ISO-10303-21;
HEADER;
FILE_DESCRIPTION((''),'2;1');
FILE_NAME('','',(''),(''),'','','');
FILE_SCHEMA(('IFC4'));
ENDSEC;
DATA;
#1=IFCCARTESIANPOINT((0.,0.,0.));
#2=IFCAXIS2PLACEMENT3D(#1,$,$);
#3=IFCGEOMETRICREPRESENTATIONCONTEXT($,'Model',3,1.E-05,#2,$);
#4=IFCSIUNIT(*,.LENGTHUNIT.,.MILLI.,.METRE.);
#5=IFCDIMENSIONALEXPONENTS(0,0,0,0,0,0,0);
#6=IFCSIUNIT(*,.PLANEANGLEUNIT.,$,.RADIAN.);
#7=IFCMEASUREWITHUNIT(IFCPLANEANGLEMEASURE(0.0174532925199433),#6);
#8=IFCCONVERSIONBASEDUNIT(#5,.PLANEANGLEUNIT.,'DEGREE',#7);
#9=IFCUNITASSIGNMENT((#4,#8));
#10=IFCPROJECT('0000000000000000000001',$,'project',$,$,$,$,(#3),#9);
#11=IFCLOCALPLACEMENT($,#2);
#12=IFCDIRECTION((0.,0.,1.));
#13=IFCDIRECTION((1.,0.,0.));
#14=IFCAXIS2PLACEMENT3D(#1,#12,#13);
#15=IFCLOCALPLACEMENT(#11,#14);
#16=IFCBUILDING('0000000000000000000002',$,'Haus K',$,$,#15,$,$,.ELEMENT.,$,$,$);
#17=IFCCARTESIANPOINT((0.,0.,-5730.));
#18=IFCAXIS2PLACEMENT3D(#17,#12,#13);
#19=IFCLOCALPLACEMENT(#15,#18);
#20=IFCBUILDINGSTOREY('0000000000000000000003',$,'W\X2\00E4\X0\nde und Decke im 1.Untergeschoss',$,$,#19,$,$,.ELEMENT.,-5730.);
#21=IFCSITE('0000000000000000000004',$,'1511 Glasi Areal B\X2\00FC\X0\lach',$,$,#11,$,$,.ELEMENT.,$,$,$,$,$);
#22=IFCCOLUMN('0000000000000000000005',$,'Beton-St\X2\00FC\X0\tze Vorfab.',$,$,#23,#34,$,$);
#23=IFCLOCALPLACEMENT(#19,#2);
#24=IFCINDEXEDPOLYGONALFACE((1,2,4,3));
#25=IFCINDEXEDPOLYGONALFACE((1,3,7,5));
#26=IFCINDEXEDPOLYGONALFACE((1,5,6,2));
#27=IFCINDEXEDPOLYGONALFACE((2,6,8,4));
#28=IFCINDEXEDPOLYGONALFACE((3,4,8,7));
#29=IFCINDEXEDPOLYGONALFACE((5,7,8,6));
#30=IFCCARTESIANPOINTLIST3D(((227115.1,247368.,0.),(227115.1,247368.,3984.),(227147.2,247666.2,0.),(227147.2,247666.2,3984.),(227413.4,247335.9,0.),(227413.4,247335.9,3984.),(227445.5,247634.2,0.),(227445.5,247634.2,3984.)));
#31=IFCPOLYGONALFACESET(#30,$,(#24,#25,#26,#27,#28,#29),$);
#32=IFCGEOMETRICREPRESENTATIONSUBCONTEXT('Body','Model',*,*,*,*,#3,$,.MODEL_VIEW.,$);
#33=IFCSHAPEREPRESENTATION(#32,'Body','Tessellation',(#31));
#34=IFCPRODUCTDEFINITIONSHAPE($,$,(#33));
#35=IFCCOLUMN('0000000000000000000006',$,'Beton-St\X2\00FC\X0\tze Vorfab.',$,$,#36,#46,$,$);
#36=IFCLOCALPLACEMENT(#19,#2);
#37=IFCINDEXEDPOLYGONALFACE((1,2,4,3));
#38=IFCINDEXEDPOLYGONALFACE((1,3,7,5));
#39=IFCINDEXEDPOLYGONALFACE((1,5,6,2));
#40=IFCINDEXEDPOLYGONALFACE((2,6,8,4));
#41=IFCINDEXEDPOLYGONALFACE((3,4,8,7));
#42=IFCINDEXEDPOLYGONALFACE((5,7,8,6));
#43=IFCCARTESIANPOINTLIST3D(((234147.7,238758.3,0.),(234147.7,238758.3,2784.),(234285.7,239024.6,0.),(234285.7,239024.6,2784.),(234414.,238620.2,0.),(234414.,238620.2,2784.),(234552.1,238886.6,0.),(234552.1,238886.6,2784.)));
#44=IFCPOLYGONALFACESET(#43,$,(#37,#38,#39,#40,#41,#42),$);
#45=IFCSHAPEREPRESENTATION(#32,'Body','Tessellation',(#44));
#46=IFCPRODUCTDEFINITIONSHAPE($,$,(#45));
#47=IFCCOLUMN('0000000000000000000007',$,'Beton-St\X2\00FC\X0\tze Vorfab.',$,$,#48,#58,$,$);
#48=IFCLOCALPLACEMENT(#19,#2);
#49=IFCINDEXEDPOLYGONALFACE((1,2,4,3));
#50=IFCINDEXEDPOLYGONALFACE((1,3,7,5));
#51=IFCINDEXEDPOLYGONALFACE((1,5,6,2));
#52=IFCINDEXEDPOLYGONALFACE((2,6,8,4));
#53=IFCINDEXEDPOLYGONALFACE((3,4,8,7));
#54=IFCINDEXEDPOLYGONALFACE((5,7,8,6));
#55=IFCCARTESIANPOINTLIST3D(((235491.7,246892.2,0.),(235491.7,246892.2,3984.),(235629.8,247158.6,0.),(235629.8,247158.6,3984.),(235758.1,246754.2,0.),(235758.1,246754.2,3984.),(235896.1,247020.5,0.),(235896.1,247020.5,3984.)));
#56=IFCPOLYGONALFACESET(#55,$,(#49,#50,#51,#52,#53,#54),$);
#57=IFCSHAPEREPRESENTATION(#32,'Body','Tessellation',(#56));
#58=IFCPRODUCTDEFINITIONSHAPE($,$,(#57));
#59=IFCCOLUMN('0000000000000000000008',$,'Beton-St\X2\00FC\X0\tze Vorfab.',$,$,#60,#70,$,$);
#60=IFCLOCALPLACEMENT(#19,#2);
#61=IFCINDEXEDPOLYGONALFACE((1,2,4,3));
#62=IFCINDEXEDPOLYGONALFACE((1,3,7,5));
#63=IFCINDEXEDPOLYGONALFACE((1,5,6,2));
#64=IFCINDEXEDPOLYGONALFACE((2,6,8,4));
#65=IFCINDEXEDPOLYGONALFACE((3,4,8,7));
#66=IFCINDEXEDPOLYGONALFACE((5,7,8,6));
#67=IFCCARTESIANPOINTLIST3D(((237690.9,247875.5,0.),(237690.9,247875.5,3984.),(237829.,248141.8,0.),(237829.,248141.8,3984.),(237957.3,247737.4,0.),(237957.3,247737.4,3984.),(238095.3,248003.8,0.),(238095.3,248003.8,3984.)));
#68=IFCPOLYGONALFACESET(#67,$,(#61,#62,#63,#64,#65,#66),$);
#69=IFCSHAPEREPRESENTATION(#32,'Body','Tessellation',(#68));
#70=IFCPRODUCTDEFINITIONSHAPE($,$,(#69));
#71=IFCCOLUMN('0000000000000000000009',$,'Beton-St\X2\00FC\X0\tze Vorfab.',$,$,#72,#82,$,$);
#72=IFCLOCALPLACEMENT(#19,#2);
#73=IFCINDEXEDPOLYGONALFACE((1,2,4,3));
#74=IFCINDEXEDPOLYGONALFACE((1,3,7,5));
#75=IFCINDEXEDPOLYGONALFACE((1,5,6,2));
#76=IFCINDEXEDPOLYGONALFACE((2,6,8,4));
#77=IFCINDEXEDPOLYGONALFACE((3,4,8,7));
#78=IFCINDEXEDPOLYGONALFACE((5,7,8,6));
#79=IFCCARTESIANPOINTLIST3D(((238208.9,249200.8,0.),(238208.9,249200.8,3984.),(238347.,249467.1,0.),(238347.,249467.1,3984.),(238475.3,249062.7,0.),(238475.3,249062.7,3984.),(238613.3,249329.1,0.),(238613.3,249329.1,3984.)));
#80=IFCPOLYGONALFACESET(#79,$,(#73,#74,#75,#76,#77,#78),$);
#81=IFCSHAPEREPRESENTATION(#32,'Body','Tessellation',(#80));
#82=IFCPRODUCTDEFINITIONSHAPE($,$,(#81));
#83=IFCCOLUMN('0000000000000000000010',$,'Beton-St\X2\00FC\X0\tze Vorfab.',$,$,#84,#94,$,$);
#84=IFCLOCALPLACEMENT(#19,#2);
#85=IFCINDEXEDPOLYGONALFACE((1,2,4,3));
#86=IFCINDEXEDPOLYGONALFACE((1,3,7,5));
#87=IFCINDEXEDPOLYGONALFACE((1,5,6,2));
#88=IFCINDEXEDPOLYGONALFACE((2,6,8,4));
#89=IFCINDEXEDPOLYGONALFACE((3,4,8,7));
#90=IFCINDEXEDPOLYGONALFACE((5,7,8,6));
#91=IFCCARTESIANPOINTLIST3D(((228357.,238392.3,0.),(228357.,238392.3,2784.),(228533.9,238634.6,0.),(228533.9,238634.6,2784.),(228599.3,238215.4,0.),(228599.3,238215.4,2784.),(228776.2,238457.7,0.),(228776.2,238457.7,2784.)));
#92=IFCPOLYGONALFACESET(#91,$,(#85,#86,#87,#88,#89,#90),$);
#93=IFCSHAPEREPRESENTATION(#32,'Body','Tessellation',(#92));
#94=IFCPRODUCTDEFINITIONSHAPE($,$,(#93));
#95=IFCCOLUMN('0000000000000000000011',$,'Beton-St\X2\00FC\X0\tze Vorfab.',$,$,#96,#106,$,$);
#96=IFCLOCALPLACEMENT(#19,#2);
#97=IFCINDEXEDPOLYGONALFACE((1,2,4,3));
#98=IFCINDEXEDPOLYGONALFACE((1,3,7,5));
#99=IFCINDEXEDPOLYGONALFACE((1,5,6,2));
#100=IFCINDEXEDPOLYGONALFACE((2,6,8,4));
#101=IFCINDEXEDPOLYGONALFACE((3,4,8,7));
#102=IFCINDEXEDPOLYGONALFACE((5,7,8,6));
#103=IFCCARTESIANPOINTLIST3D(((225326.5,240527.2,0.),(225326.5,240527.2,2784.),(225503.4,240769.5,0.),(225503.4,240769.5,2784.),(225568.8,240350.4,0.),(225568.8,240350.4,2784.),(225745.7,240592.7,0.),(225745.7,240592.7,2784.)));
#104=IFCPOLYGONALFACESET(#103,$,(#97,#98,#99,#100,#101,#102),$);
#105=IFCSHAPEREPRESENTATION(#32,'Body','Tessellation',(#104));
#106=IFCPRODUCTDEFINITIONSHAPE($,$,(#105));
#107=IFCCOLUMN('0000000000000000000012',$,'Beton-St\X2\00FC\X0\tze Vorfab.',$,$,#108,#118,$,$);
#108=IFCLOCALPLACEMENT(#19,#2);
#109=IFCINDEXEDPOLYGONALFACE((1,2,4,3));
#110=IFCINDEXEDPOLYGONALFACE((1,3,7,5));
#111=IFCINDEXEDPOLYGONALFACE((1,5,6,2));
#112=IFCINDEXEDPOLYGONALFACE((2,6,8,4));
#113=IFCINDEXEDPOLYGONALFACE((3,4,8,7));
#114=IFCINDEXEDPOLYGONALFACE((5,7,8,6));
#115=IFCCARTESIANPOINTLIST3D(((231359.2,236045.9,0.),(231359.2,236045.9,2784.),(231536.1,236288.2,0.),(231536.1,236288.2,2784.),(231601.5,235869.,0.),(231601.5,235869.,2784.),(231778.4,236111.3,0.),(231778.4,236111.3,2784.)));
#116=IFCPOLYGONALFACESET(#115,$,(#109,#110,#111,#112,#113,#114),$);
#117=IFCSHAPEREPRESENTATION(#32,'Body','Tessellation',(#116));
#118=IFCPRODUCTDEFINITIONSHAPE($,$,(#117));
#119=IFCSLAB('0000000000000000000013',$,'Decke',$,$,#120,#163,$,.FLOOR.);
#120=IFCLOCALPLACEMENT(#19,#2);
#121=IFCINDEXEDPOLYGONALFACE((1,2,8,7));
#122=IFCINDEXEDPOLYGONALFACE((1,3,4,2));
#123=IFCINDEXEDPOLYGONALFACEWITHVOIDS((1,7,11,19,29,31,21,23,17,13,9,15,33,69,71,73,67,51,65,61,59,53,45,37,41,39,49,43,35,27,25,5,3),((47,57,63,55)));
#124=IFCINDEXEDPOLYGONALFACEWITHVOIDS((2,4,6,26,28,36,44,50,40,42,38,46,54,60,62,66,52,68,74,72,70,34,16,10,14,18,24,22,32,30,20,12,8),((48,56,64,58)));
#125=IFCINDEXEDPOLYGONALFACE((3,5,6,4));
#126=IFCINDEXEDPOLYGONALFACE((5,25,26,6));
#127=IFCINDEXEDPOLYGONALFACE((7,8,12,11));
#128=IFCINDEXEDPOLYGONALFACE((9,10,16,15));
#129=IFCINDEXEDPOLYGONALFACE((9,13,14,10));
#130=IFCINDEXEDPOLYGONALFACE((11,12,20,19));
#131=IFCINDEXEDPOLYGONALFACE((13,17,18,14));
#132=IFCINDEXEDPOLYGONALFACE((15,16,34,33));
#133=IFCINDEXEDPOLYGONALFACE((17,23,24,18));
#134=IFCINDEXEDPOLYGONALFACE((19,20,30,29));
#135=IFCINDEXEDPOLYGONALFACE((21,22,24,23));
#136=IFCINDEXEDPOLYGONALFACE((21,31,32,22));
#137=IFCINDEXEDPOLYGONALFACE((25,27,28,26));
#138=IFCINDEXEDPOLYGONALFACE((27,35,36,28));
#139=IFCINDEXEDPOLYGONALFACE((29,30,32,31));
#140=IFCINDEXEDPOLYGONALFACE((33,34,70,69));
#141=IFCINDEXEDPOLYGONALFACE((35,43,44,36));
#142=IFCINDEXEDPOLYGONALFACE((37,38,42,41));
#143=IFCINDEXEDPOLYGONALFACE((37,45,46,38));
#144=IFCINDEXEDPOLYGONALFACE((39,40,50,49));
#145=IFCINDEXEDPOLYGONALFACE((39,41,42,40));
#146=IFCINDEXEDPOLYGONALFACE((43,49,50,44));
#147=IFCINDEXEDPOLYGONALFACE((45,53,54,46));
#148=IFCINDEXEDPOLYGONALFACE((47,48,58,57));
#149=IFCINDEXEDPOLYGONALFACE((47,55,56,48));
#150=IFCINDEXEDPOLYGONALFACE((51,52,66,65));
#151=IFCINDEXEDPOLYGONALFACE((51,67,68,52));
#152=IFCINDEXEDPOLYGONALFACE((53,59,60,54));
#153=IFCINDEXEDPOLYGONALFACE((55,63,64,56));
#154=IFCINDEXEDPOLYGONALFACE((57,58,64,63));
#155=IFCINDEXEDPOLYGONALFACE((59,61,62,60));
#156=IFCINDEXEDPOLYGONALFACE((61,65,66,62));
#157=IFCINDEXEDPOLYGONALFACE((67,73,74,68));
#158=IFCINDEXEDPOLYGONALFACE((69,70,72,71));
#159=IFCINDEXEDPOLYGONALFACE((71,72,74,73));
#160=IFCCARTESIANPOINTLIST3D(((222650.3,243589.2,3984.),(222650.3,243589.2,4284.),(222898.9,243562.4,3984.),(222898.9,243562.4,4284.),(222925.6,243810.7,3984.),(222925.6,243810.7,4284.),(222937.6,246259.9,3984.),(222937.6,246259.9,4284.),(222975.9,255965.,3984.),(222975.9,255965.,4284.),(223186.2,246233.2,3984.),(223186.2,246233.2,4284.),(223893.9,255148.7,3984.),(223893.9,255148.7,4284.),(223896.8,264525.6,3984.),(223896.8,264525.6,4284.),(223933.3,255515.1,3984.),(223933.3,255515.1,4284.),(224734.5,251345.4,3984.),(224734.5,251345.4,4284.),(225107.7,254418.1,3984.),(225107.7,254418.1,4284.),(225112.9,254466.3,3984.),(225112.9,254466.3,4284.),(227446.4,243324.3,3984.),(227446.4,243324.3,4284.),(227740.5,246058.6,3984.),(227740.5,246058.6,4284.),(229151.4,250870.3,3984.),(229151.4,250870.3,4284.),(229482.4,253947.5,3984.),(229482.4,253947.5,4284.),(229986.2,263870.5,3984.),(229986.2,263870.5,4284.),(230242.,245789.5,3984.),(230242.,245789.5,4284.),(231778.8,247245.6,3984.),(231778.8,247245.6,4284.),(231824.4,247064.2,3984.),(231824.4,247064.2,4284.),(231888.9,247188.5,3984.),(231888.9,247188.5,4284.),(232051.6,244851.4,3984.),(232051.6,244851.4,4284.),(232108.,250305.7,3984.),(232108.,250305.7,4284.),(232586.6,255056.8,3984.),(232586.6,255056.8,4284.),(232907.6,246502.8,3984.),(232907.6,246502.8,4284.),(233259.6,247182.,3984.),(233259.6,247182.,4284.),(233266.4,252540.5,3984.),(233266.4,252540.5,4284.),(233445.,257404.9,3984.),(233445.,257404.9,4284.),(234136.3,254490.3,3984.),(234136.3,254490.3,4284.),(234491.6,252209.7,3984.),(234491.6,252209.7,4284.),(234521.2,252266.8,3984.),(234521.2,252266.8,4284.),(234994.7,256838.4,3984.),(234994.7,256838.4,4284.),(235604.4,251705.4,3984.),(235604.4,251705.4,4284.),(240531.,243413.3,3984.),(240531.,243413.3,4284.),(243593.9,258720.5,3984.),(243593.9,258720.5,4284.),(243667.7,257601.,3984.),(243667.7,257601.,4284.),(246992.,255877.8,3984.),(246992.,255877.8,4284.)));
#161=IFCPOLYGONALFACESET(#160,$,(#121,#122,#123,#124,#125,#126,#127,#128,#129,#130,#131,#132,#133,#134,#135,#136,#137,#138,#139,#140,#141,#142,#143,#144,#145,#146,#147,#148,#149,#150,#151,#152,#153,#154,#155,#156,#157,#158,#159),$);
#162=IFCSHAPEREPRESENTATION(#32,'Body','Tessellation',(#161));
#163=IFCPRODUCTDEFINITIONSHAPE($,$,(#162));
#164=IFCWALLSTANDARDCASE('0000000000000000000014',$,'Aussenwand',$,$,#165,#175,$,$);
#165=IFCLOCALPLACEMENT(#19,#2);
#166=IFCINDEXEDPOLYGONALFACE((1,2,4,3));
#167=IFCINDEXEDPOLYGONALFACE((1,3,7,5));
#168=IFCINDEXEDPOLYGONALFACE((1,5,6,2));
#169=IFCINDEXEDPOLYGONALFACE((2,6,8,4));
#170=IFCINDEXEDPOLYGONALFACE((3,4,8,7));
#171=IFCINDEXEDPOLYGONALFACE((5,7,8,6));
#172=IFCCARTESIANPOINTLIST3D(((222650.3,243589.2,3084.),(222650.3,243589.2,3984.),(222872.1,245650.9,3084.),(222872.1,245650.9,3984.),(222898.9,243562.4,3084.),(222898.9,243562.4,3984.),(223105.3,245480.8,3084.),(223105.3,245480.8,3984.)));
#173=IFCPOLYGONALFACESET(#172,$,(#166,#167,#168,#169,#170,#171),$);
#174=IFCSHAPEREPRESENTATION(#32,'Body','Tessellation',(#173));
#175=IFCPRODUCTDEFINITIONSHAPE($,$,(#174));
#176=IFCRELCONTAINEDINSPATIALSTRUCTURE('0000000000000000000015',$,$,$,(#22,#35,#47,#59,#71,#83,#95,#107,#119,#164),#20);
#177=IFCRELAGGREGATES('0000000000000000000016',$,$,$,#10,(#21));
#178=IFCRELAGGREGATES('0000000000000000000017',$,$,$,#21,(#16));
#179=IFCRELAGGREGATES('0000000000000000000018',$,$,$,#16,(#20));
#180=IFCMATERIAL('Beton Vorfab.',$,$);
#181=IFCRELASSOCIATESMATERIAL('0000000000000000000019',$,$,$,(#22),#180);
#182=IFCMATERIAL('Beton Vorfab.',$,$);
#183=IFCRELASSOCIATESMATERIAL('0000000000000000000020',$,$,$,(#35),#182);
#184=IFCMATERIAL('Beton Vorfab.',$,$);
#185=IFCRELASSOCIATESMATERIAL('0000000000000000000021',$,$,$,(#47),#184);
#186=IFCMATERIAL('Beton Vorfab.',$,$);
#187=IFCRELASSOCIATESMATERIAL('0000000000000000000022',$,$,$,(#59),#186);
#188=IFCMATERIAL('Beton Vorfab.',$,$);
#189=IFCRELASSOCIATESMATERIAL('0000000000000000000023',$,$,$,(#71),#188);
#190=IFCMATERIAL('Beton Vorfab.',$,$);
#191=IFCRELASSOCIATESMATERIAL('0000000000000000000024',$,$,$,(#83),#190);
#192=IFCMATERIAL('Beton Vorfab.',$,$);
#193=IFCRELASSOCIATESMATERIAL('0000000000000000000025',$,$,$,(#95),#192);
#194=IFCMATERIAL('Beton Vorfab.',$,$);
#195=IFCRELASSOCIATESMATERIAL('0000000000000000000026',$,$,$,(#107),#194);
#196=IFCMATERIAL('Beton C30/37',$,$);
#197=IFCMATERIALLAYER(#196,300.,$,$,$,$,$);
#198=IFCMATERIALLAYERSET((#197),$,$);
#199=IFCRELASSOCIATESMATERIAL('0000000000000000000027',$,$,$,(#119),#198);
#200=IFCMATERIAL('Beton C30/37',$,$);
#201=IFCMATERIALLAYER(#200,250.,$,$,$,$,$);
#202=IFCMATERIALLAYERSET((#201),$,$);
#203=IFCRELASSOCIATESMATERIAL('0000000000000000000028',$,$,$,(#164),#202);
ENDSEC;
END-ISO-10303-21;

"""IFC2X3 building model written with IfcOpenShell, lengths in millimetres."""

from ifc_helpers import new_model, entity, si_unit, converted_unit, frame, frame_2d, origin, origin_with_axes, place, context, subcontext, project, spatial, polyline, rectangle, outline, extrude, material, layer, layer_set, layer_usage, element, save


model = new_model("IFC2X3")

# Units and contexts
model_context = context("Model", 3, precision=1e-05, world=origin())
body_context = subcontext(model_context, "Body", "Model", "MODEL_VIEW")
ifc_project = project(units=[si_unit("LENGTHUNIT", "METRE", prefix="MILLI"), converted_unit("PLANEANGLEUNIT", "DEGREE", entity("IfcPlaneAngleMeasure", 0.0174532925199433), si_unit("PLANEANGLEUNIT", "RADIAN"), dimensions=[0, 0, 0, 0, 0, 0, 0])], contexts=[model_context])

# Site, building, storey
site_placement = place(None, origin())
site = spatial("IfcSite", under=ifc_project, at=site_placement, Name="1511 Glasi Areal Bülach", CompositionType="ELEMENT")
building_placement = place(site_placement, origin_with_axes())
building = spatial("IfcBuilding", under=site, at=building_placement, Name="Haus K", CompositionType="ELEMENT")
storey_placement = place(building_placement, frame((0.0, 0.0, -5730.0), z_axis=(0.0, 0.0, 1.0), x_axis=(1.0, 0.0, 0.0)))
storey = spatial("IfcBuildingStorey", under=building, at=storey_placement, Name="Wände und Decke im 1.Untergeschoss", CompositionType="ELEMENT", Elevation=-5730.0)

# Columns
ifc_material_1 = material(Name="Beton Vorfab.")
column_1_placement = place(storey_placement, frame((227115.1, 247368.0, 0.0), z_axis=(0.0, 0.0, 1.0), x_axis=(1.0, 0.0, 0.0)))
element("IfcColumn", 1, at=column_1_placement, inside=storey, material=ifc_material_1, Name="Beton-Stütze Vorfab.", context=body_context, shape_type="SweptSolid", body=[
    extrude(rectangle(XDim=300.0, YDim=300.0, at=frame_2d((165.2, 133.1), x_axis=(0.994264, -0.106958))), origin_with_axes(), (0.0, 0.0, 1.0), 3984.0),
])
ifc_material_2 = material(Name="Beton Vorfab.")
column_2_placement = place(storey_placement, frame((234147.7, 238758.3, 0.0), z_axis=(0.0, 0.0, 1.0), x_axis=(1.0, 0.0, 0.0)))
element("IfcColumn", 2, at=column_2_placement, inside=storey, material=ifc_material_2, Name="Beton-Stütze Vorfab.", context=body_context, shape_type="SweptSolid", body=[
    extrude(rectangle(XDim=300.0, YDim=300.0, at=frame_2d((202.2, 64.1), x_axis=(0.887815, -0.4602))), origin_with_axes(), (0.0, 0.0, 1.0), 2784.0),
])
ifc_material_3 = material(Name="Beton Vorfab.")
column_3_placement = place(storey_placement, frame((235491.7, 246892.2, 0.0), z_axis=(0.0, 0.0, 1.0), x_axis=(1.0, 0.0, 0.0)))
element("IfcColumn", 3, at=column_3_placement, inside=storey, material=ifc_material_3, Name="Beton-Stütze Vorfab.", context=body_context, shape_type="SweptSolid", body=[
    extrude(rectangle(XDim=300.0, YDim=300.0, at=frame_2d((202.2, 64.1), x_axis=(0.887815, -0.4602))), origin_with_axes(), (0.0, 0.0, 1.0), 3984.0),
])
ifc_material_4 = material(Name="Beton Vorfab.")
column_4_placement = place(storey_placement, frame((237690.9, 247875.5, 0.0), z_axis=(0.0, 0.0, 1.0), x_axis=(1.0, 0.0, 0.0)))
element("IfcColumn", 4, at=column_4_placement, inside=storey, material=ifc_material_4, Name="Beton-Stütze Vorfab.", context=body_context, shape_type="SweptSolid", body=[
    extrude(rectangle(XDim=300.0, YDim=300.0, at=frame_2d((202.2, 64.1), x_axis=(0.887815, -0.4602))), origin_with_axes(), (0.0, 0.0, 1.0), 3984.0),
])
ifc_material_5 = material(Name="Beton Vorfab.")
column_5_placement = place(storey_placement, frame((238208.9, 249200.8, 0.0), z_axis=(0.0, 0.0, 1.0), x_axis=(1.0, 0.0, 0.0)))
element("IfcColumn", 5, at=column_5_placement, inside=storey, material=ifc_material_5, Name="Beton-Stütze Vorfab.", context=body_context, shape_type="SweptSolid", body=[
    extrude(rectangle(XDim=300.0, YDim=300.0, at=frame_2d((202.2, 64.1), x_axis=(0.887815, -0.4602))), origin_with_axes(), (0.0, 0.0, 1.0), 3984.0),
])
ifc_material_6 = material(Name="Beton Vorfab.")
column_6_placement = place(storey_placement, frame((228357.0, 238392.3, 0.0), z_axis=(0.0, 0.0, 1.0), x_axis=(1.0, 0.0, 0.0)))
element("IfcColumn", 6, at=column_6_placement, inside=storey, material=ifc_material_6, Name="Beton-Stütze Vorfab.", context=body_context, shape_type="SweptSolid", body=[
    extrude(rectangle(XDim=300.0, YDim=300.0, at=frame_2d((209.6, 32.7), x_axis=(0.807681, -0.589619))), origin_with_axes(), (0.0, 0.0, 1.0), 2784.0),
])
ifc_material_7 = material(Name="Beton Vorfab.")
column_7_placement = place(storey_placement, frame((225326.5, 240527.2, 0.0), z_axis=(0.0, 0.0, 1.0), x_axis=(1.0, 0.0, 0.0)))
element("IfcColumn", 7, at=column_7_placement, inside=storey, material=ifc_material_7, Name="Beton-Stütze Vorfab.", context=body_context, shape_type="SweptSolid", body=[
    extrude(rectangle(XDim=300.0, YDim=300.0, at=frame_2d((209.6, 32.7), x_axis=(0.807681, -0.589619))), origin_with_axes(), (0.0, 0.0, 1.0), 2784.0),
])
ifc_material_8 = material(Name="Beton Vorfab.")
column_8_placement = place(storey_placement, frame((231359.2, 236045.9, 0.0), z_axis=(0.0, 0.0, 1.0), x_axis=(1.0, 0.0, 0.0)))
element("IfcColumn", 8, at=column_8_placement, inside=storey, material=ifc_material_8, Name="Beton-Stütze Vorfab.", context=body_context, shape_type="SweptSolid", body=[
    extrude(rectangle(XDim=300.0, YDim=300.0, at=frame_2d((209.6, 32.7), x_axis=(0.807681, -0.589619))), origin_with_axes(), (0.0, 0.0, 1.0), 2784.0),
])

# Slab, openings
ifc_material_9 = material(Name="Beton C30/37")
ifc_layer_1 = layer(ifc_material_9, 300.0)
ifc_layer_set_1 = layer_set([ifc_layer_1])
ifc_layer_usage_1 = layer_usage(ifc_layer_set_1, "AXIS3", "POSITIVE", 0.0)
slab_placement = place(storey_placement, frame((222650.3, 243324.3, 3984.0), z_axis=(0.0, 0.0, 1.0), x_axis=(1.0, 0.0, 0.0)))
slab = element("IfcSlab", 9, at=slab_placement, inside=storey, material=ifc_layer_usage_1, Name="Decke", PredefinedType="FLOOR", context=body_context, shape_type="SweptSolid", body=[
    extrude(outline(polyline([(20943.6, 15396.1), (7335.9, 20546.2), (1246.5, 21201.3), (325.6, 12640.7), (1243.5, 11824.4), (1282.9, 12190.8), (2462.5, 11142.0), (2457.3, 11093.8), (6832.1, 10623.2), (6501.1, 7545.9), (2084.2, 8021.1), (535.9, 2908.9), (287.3, 2935.6), (0.0, 264.8), (248.6, 238.1), (275.3, 486.3), (4796.0, 0.0), (5090.2, 2734.2), (7591.7, 2465.1), (9401.3, 1527.1), (10609.3, 3857.6), (17880.7, 89.0), (24341.7, 12553.5), (21017.4, 14276.7), (20943.6, 15396.1)])), origin_with_axes(), (0.0, 0.0, 1.0), 300.0),
])
opening_1_placement = place(slab_placement, frame((10794.6, 14080.5, 0.0), z_axis=(0.0, 0.0, 1.0), x_axis=(1.0, 0.0, 0.0)))
element("IfcOpeningElement", 10, at=opening_1_placement, cuts=slab, ObjectType="Opening", context=body_context, shape_type="SweptSolid", body=[
    extrude(rectangle(XDim=2500.0, YDim=1650.0, at=frame_2d((345.7, -1457.3), x_axis=(-0.343332, -0.939214))), origin_with_axes(), (0.0, 0.0, 1.0), 300.0),
])
opening_2_placement = place(slab_placement, frame((10321.7, 3302.7, -700.0), z_axis=(0.0, 0.0, 1.0), x_axis=(1.0, 0.0, 0.0)))
element("IfcOpeningElement", 11, at=opening_2_placement, cuts=slab, ObjectType="Recess", context=body_context, shape_type="SweptSolid", body=[
    extrude(rectangle(XDim=1220.0, YDim=140.0, at=frame_2d((-573.8, 218.6), x_axis=(-0.887815, 0.4602))), origin_with_axes(), (0.0, 0.0, 1.0), 1000.0),
])
opening_3_placement = place(slab_placement, frame((9128.4, 3302.7, 0.0), z_axis=(0.0, 0.0, 1.0), x_axis=(1.0, 0.0, 0.0)))
element("IfcOpeningElement", 12, at=opening_3_placement, cuts=slab, ObjectType="Opening", context=body_context, shape_type="SweptSolid", body=[
    extrude(outline(polyline([(2712.8, 5582.7), (1487.6, 5913.4), (329.2, 3678.6), (0.0, 618.5), (1193.2, 0.0), (3825.6, 5078.3), (2742.4, 5639.7), (2712.8, 5582.7)])), origin_with_axes(), (0.0, 0.0, 1.0), 300.0),
])

# Wall
ifc_material_10 = material(Name="Beton C30/37")
ifc_layer_2 = layer(ifc_material_10, 250.0)
ifc_layer_set_2 = layer_set([ifc_layer_2])
ifc_layer_usage_2 = layer_usage(ifc_layer_set_2, "AXIS2", "POSITIVE", 0.0)
wall_1_placement = place(storey_placement, frame((222872.1, 245650.9, 3084.0), z_axis=(0.0, 0.0, 1.0), x_axis=(-0.106958, -0.994264, 0.0)))
element("IfcWallStandardCase", 13, at=wall_1_placement, inside=storey, material=ifc_layer_usage_2, Name="Aussenwand", context=body_context, shape_type="SweptSolid", body=[
    extrude(outline(polyline([(0.0, 0.0), (2073.7, 0.0), (2073.7, 250.0), (144.3, 250.0), (0.0, 0.0)])), origin_with_axes(), (0.0, 0.0, 1.0), 900.0),
])

save(model, "model.ifc")
